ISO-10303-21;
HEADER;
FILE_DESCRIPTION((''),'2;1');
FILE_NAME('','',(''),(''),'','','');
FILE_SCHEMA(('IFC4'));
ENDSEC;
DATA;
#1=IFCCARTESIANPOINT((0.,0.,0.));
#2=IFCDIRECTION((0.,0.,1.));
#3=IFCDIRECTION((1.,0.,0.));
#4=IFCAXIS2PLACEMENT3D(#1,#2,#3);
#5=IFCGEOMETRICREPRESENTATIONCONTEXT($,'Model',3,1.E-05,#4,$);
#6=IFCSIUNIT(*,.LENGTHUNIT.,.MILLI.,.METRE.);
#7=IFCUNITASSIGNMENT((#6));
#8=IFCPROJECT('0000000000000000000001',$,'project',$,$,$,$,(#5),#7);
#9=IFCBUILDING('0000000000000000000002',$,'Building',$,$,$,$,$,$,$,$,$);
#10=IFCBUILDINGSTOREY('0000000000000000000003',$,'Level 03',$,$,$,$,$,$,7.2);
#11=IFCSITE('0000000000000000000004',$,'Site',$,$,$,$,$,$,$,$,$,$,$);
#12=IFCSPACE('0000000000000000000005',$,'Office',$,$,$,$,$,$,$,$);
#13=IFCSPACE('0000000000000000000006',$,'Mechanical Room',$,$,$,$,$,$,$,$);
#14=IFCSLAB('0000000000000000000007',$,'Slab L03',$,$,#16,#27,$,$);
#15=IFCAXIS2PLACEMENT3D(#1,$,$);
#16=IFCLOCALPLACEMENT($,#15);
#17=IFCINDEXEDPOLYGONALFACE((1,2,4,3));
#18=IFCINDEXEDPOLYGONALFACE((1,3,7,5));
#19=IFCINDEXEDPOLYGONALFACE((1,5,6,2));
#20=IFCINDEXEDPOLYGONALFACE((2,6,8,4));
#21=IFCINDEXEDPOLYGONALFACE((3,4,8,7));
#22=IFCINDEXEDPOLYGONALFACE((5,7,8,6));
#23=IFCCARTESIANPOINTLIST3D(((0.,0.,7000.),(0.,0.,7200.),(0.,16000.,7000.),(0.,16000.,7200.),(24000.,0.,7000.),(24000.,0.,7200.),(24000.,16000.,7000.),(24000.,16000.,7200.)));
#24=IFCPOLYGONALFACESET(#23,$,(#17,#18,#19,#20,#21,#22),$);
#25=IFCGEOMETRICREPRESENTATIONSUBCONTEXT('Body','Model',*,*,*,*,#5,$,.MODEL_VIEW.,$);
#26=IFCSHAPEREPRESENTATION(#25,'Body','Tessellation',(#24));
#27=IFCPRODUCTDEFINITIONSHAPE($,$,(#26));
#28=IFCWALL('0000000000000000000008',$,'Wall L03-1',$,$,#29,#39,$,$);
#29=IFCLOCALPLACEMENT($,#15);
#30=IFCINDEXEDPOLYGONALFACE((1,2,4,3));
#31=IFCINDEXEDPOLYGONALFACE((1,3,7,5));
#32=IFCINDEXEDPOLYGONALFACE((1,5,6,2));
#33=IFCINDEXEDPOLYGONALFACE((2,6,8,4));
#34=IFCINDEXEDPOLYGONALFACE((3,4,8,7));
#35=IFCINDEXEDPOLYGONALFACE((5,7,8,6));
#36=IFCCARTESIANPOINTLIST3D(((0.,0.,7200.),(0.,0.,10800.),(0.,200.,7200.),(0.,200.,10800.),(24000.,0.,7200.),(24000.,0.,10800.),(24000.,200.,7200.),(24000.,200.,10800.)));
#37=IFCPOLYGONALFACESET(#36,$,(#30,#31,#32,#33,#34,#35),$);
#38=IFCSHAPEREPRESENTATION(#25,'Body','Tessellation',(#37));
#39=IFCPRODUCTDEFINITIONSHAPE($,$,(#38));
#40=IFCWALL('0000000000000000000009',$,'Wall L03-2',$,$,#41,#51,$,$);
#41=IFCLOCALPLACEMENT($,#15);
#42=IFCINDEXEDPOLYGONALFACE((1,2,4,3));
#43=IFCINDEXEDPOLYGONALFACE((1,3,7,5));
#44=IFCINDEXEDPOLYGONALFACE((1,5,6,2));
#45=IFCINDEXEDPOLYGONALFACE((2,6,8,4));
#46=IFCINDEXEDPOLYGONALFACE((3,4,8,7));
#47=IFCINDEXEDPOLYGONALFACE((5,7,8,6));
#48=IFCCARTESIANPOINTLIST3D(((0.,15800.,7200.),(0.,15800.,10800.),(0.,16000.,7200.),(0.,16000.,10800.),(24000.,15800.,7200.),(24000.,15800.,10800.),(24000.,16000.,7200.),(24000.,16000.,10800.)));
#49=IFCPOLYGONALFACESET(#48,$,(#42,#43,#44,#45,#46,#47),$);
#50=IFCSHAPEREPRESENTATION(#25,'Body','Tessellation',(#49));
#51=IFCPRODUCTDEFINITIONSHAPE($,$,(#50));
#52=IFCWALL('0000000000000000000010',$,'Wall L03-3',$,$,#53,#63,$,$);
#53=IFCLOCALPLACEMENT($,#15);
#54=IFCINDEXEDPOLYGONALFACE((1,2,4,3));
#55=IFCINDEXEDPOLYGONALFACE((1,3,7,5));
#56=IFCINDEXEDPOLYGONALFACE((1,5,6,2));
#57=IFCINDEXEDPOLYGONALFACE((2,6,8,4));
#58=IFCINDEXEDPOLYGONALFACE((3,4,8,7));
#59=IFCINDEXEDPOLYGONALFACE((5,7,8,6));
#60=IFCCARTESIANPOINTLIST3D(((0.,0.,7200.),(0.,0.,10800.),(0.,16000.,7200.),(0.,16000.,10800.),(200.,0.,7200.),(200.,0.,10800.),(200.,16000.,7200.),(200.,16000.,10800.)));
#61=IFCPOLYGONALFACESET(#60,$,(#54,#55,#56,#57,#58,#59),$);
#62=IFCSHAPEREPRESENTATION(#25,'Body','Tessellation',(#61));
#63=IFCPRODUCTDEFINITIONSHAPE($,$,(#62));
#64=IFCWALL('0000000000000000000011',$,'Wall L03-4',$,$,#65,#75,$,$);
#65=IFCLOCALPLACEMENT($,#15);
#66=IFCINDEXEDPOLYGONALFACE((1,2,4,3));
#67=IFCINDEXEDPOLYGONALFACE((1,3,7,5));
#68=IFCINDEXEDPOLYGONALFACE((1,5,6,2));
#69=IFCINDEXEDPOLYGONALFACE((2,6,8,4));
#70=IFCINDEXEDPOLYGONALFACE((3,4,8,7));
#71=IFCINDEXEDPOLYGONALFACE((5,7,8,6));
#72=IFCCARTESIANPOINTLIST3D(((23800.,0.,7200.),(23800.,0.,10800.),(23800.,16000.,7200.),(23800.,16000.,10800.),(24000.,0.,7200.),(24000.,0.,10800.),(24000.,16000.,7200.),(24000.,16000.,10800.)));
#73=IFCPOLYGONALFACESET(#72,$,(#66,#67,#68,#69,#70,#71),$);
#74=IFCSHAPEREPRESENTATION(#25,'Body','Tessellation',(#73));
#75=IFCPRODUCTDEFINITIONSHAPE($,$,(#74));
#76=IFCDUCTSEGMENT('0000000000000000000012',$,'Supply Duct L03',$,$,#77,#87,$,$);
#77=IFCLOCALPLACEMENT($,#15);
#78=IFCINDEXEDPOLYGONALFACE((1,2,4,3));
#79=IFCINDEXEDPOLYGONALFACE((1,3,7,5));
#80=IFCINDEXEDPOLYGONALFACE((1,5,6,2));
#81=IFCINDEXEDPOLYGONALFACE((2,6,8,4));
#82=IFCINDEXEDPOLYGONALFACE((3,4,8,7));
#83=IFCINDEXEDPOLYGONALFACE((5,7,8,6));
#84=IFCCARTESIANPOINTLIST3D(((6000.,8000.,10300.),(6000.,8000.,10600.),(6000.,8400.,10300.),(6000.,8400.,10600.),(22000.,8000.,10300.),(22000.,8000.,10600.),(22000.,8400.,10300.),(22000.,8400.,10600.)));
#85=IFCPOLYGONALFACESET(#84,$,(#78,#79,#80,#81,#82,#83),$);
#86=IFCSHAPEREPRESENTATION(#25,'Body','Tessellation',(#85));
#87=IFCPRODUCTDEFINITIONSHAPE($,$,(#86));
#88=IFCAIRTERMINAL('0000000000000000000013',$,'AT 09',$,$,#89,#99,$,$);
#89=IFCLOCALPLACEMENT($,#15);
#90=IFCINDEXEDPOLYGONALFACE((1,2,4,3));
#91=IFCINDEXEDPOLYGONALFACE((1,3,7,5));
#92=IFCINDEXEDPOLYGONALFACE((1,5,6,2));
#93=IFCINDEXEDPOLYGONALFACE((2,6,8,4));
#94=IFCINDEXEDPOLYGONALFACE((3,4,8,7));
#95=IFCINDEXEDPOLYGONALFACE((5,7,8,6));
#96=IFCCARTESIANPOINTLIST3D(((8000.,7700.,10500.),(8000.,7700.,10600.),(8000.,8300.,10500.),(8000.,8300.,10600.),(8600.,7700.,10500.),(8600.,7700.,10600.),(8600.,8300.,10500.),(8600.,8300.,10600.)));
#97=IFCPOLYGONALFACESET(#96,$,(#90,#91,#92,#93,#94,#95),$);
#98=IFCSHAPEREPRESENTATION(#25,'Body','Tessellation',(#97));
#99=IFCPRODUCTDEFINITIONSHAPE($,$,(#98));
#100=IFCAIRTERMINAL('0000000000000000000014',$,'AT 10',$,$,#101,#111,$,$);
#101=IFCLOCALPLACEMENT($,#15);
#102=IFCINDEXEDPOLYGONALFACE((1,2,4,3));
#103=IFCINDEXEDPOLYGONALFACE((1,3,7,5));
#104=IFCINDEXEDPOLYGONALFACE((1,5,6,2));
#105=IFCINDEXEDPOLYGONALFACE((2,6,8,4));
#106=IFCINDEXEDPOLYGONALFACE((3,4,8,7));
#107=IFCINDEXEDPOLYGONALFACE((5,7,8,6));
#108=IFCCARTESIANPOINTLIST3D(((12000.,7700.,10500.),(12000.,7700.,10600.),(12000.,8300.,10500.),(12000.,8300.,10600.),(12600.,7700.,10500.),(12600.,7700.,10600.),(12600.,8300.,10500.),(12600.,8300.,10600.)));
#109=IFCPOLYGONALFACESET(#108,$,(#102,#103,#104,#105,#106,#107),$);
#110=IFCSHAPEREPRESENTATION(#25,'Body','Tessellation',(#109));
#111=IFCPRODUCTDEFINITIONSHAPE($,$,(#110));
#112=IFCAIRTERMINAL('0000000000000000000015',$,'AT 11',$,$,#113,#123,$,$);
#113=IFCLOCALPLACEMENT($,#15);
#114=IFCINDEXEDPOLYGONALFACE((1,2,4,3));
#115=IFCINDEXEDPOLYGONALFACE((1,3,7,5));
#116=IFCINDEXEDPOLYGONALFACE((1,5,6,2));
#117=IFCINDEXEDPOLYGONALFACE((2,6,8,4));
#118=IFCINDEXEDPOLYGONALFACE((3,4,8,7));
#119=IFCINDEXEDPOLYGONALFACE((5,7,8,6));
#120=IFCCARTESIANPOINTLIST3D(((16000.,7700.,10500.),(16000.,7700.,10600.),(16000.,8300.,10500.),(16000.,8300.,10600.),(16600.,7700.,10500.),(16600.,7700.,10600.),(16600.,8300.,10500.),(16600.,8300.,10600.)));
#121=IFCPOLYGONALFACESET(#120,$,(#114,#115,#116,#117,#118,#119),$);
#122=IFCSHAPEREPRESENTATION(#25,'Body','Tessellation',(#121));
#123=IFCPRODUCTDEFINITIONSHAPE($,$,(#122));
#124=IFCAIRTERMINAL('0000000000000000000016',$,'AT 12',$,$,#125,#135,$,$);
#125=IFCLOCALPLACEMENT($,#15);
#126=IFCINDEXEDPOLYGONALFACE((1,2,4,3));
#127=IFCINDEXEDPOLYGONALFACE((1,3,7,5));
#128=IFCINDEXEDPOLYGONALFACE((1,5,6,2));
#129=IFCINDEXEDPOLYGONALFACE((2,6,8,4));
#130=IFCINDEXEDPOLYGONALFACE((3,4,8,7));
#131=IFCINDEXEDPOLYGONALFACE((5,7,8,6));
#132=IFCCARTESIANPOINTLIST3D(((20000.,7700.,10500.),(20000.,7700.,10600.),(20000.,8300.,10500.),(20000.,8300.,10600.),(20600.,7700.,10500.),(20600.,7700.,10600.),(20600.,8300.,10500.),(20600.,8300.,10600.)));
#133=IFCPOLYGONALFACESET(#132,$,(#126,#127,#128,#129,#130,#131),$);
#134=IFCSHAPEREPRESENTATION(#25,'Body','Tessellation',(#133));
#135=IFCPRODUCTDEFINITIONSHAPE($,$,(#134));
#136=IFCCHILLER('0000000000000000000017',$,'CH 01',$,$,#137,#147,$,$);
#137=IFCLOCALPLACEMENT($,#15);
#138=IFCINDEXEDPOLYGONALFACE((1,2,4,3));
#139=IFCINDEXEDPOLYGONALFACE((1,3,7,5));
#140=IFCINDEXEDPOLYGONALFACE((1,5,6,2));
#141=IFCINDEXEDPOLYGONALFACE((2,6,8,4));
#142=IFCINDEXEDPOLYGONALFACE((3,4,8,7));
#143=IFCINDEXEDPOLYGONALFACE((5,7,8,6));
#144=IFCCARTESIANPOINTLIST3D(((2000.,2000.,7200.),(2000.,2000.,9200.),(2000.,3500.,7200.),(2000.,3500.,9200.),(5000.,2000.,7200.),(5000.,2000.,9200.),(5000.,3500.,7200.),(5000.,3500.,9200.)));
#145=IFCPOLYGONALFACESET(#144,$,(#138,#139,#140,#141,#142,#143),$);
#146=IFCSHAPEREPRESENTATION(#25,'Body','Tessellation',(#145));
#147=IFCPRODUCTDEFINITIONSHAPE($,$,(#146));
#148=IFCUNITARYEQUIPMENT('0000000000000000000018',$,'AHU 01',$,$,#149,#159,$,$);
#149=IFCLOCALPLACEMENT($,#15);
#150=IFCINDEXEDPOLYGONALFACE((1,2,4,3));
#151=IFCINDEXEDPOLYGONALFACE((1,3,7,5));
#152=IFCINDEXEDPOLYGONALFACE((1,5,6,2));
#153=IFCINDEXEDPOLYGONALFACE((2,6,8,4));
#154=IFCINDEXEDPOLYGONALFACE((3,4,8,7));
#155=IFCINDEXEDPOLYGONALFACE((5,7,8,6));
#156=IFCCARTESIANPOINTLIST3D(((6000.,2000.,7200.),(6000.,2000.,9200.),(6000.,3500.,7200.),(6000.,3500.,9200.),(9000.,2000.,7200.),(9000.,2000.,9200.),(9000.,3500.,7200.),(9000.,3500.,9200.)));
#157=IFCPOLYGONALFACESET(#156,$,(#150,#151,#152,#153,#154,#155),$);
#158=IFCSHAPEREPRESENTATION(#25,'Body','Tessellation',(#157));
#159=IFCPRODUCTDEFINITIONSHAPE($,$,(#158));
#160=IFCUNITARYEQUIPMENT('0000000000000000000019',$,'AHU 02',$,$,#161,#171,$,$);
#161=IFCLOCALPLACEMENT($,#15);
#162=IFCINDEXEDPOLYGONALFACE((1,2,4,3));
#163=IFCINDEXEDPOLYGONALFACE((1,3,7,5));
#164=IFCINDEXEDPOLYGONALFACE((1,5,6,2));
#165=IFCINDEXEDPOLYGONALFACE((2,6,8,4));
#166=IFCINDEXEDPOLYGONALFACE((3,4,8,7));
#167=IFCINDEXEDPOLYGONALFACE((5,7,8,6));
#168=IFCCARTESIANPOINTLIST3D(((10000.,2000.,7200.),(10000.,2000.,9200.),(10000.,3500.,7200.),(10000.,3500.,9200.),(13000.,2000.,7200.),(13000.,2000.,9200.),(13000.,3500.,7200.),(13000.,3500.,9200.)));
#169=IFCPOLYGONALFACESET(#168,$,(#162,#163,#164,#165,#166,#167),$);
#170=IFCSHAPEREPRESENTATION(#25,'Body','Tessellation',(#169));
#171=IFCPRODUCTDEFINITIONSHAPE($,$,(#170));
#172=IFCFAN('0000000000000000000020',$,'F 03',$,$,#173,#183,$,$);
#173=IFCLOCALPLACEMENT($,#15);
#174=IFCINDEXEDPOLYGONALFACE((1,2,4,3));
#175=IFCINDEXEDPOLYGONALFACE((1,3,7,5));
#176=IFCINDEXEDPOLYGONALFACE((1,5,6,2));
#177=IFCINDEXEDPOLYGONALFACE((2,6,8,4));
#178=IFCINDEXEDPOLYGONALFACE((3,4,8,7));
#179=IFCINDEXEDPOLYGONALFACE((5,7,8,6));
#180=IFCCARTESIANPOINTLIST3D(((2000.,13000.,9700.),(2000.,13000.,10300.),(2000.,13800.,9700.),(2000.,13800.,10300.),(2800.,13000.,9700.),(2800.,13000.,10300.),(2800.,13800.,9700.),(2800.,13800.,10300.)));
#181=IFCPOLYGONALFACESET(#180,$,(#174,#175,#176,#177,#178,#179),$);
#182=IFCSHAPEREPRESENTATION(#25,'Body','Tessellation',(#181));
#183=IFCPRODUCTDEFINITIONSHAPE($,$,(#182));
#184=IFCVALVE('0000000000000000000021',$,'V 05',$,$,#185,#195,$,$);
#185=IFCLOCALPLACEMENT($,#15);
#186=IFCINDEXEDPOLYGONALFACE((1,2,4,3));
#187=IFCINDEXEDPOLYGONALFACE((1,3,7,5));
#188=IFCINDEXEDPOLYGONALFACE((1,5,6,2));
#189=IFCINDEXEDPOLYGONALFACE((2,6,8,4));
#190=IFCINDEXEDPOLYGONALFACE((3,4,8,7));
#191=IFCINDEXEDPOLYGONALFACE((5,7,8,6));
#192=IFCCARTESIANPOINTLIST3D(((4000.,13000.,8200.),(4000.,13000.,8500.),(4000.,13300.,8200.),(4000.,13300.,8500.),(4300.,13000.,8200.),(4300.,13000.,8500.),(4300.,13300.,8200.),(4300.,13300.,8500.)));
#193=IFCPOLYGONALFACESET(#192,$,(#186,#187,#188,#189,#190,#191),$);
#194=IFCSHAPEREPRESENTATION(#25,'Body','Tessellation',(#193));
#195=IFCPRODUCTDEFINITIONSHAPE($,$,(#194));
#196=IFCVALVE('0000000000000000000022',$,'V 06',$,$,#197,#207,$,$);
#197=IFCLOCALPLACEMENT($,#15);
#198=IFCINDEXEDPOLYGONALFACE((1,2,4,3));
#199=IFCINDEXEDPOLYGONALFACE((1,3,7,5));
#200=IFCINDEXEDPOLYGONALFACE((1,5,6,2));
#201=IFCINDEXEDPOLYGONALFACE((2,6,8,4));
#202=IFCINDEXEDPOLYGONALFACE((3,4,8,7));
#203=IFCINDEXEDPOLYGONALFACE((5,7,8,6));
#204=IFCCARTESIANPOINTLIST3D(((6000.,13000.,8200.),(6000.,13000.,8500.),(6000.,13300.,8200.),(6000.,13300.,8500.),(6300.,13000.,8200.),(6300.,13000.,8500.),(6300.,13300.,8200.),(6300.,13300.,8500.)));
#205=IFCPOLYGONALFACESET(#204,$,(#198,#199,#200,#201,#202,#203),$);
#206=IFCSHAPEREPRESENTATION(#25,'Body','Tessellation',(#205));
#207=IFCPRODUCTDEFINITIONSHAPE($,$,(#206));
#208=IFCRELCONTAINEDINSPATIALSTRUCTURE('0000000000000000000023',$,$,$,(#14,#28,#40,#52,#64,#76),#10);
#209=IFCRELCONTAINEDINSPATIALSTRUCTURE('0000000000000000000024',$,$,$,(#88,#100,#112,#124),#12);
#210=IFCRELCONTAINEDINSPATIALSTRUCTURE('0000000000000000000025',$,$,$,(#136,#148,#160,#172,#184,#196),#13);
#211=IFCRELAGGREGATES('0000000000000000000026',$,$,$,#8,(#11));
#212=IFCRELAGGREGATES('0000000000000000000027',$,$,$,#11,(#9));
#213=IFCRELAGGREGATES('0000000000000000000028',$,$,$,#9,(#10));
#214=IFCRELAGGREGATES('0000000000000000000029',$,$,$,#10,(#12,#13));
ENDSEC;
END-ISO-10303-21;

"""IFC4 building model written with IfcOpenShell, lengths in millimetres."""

from ifc_helpers import new_model, si_unit, frame, origin_with_axes, place, context, subcontext, project, spatial, indexed_curve, outline, extrude, element, save


model = new_model("IFC4")

# Units and contexts
model_context = context("Model", 3, precision=1e-05, world=origin_with_axes())
body_context = subcontext(model_context, "Body", "Model", "MODEL_VIEW")
ifc_project = project(units=[si_unit("LENGTHUNIT", "METRE", prefix="MILLI")], contexts=[model_context])

# Site, building, storey
site = spatial("IfcSite", under=ifc_project, Name="Site")
building = spatial("IfcBuilding", under=site, Name="Building")
storey = spatial("IfcBuildingStorey", under=building, Name="Level 03", Elevation=7.2)

# Slab
slab_placement = place(None, frame((0.0, 0.0, 7000.0), z_axis=(0.0, 0.0, 1.0), x_axis=(1.0, 0.0, 0.0)))
element("IfcSlab", 1, at=slab_placement, inside=storey, Name="Slab L03", context=body_context, shape_type="SweptSolid", body=[
    extrude(outline(indexed_curve([(0.0, 0.0), (0.0, 16000.0), (24000.0, 16000.0), (24000.0, 0.0), (0.0, 0.0)], self_intersect=False)), origin_with_axes(), (0.0, 0.0, 1.0), 200.0),
])

# Walls
for number, where, z_axis, x_axis, name in (
    (2, (0.0, 0.0, 7200.0), (0.0, 0.0, 1.0), (1.0, 0.0, 0.0), "Wall L03-1"),
    (3, (0.0, 15800.0, 7200.0), (0.0, 0.0, 1.0), (1.0, 0.0, 0.0), "Wall L03-2"),
):
    element("IfcWall", number, at=place(None, frame(where, z_axis=z_axis, x_axis=x_axis)), inside=storey, Name=name, context=body_context, shape_type="SweptSolid", body=[
        extrude(outline(indexed_curve([(0.0, 0.0), (0.0, 200.0), (24000.0, 200.0), (24000.0, 0.0), (0.0, 0.0)], self_intersect=False)), origin_with_axes(), (0.0, 0.0, 1.0), 3600.0),
    ])
for number, where, z_axis, x_axis, name in (
    (4, (0.0, 0.0, 7200.0), (0.0, 0.0, 1.0), (1.0, 0.0, 0.0), "Wall L03-3"),
    (5, (23800.0, 0.0, 7200.0), (0.0, 0.0, 1.0), (1.0, 0.0, 0.0), "Wall L03-4"),
):
    element("IfcWall", number, at=place(None, frame(where, z_axis=z_axis, x_axis=x_axis)), inside=storey, Name=name, context=body_context, shape_type="SweptSolid", body=[
        extrude(outline(indexed_curve([(0.0, 0.0), (0.0, 16000.0), (200.0, 16000.0), (200.0, 0.0), (0.0, 0.0)], self_intersect=False)), origin_with_axes(), (0.0, 0.0, 1.0), 3600.0),
    ])

# Duct segment
duct_segment_placement = place(None, frame((6000.0, 8000.0, 10300.0), z_axis=(0.0, 0.0, 1.0), x_axis=(1.0, 0.0, 0.0)))
element("IfcDuctSegment", 6, at=duct_segment_placement, inside=storey, Name="Supply Duct L03", context=body_context, shape_type="SweptSolid", body=[
    extrude(outline(indexed_curve([(0.0, 0.0), (0.0, 400.0), (16000.0, 400.0), (16000.0, 0.0), (0.0, 0.0)], self_intersect=False)), origin_with_axes(), (0.0, 0.0, 1.0), 300.0),
])

# Shared definitions
space_1 = spatial("IfcSpace", under=storey, Name="Office")

# Air terminals
for number, where, z_axis, x_axis, name in (
    (7, (8000.0, 7700.0, 10500.0), (0.0, 0.0, 1.0), (1.0, 0.0, 0.0), "AT 09"),
    (8, (12000.0, 7700.0, 10500.0), (0.0, 0.0, 1.0), (1.0, 0.0, 0.0), "AT 10"),
    (9, (16000.0, 7700.0, 10500.0), (0.0, 0.0, 1.0), (1.0, 0.0, 0.0), "AT 11"),
    (10, (20000.0, 7700.0, 10500.0), (0.0, 0.0, 1.0), (1.0, 0.0, 0.0), "AT 12"),
):
    element("IfcAirTerminal", number, at=place(None, frame(where, z_axis=z_axis, x_axis=x_axis)), inside=space_1, Name=name, context=body_context, shape_type="SweptSolid", body=[
        extrude(outline(indexed_curve([(0.0, 0.0), (0.0, 600.0), (600.0, 600.0), (600.0, 0.0), (0.0, 0.0)], self_intersect=False)), origin_with_axes(), (0.0, 0.0, 1.0), 100.0),
    ])

# Shared definitions
space_2 = spatial("IfcSpace", under=storey, Name="Mechanical Room")

# Chiller
chiller_placement = place(None, frame((2000.0, 2000.0, 7200.0), z_axis=(0.0, 0.0, 1.0), x_axis=(1.0, 0.0, 0.0)))
element("IfcChiller", 11, at=chiller_placement, inside=space_2, Name="CH 01", context=body_context, shape_type="SweptSolid", body=[
    extrude(outline(indexed_curve([(0.0, 0.0), (0.0, 1500.0), (3000.0, 1500.0), (3000.0, 0.0), (0.0, 0.0)], self_intersect=False)), origin_with_axes(), (0.0, 0.0, 1.0), 2000.0),
])

# Unitary equipment
for number, where, z_axis, x_axis, name in (
    (12, (6000.0, 2000.0, 7200.0), (0.0, 0.0, 1.0), (1.0, 0.0, 0.0), "AHU 01"),
    (13, (10000.0, 2000.0, 7200.0), (0.0, 0.0, 1.0), (1.0, 0.0, 0.0), "AHU 02"),
):
    element("IfcUnitaryEquipment", number, at=place(None, frame(where, z_axis=z_axis, x_axis=x_axis)), inside=space_2, Name=name, context=body_context, shape_type="SweptSolid", body=[
        extrude(outline(indexed_curve([(0.0, 0.0), (0.0, 1500.0), (3000.0, 1500.0), (3000.0, 0.0), (0.0, 0.0)], self_intersect=False)), origin_with_axes(), (0.0, 0.0, 1.0), 2000.0),
    ])

# Fan
fan_placement = place(None, frame((2000.0, 13000.0, 9700.0), z_axis=(0.0, 0.0, 1.0), x_axis=(1.0, 0.0, 0.0)))
element("IfcFan", 14, at=fan_placement, inside=space_2, Name="F 03", context=body_context, shape_type="SweptSolid", body=[
    extrude(outline(indexed_curve([(0.0, 0.0), (0.0, 800.0), (800.0, 800.0), (800.0, 0.0), (0.0, 0.0)], self_intersect=False)), origin_with_axes(), (0.0, 0.0, 1.0), 600.0),
])

# Valves
for number, where, z_axis, x_axis, name in (
    (15, (4000.0, 13000.0, 8200.0), (0.0, 0.0, 1.0), (1.0, 0.0, 0.0), "V 05"),
    (16, (6000.0, 13000.0, 8200.0), (0.0, 0.0, 1.0), (1.0, 0.0, 0.0), "V 06"),
):
    element("IfcValve", number, at=place(None, frame(where, z_axis=z_axis, x_axis=x_axis)), inside=space_2, Name=name, context=body_context, shape_type="SweptSolid", body=[
        extrude(outline(indexed_curve([(0.0, 0.0), (0.0, 300.0), (300.0, 300.0), (300.0, 0.0), (0.0, 0.0)], self_intersect=False)), origin_with_axes(), (0.0, 0.0, 1.0), 300.0),
    ])

save(model, "model.ifc")
